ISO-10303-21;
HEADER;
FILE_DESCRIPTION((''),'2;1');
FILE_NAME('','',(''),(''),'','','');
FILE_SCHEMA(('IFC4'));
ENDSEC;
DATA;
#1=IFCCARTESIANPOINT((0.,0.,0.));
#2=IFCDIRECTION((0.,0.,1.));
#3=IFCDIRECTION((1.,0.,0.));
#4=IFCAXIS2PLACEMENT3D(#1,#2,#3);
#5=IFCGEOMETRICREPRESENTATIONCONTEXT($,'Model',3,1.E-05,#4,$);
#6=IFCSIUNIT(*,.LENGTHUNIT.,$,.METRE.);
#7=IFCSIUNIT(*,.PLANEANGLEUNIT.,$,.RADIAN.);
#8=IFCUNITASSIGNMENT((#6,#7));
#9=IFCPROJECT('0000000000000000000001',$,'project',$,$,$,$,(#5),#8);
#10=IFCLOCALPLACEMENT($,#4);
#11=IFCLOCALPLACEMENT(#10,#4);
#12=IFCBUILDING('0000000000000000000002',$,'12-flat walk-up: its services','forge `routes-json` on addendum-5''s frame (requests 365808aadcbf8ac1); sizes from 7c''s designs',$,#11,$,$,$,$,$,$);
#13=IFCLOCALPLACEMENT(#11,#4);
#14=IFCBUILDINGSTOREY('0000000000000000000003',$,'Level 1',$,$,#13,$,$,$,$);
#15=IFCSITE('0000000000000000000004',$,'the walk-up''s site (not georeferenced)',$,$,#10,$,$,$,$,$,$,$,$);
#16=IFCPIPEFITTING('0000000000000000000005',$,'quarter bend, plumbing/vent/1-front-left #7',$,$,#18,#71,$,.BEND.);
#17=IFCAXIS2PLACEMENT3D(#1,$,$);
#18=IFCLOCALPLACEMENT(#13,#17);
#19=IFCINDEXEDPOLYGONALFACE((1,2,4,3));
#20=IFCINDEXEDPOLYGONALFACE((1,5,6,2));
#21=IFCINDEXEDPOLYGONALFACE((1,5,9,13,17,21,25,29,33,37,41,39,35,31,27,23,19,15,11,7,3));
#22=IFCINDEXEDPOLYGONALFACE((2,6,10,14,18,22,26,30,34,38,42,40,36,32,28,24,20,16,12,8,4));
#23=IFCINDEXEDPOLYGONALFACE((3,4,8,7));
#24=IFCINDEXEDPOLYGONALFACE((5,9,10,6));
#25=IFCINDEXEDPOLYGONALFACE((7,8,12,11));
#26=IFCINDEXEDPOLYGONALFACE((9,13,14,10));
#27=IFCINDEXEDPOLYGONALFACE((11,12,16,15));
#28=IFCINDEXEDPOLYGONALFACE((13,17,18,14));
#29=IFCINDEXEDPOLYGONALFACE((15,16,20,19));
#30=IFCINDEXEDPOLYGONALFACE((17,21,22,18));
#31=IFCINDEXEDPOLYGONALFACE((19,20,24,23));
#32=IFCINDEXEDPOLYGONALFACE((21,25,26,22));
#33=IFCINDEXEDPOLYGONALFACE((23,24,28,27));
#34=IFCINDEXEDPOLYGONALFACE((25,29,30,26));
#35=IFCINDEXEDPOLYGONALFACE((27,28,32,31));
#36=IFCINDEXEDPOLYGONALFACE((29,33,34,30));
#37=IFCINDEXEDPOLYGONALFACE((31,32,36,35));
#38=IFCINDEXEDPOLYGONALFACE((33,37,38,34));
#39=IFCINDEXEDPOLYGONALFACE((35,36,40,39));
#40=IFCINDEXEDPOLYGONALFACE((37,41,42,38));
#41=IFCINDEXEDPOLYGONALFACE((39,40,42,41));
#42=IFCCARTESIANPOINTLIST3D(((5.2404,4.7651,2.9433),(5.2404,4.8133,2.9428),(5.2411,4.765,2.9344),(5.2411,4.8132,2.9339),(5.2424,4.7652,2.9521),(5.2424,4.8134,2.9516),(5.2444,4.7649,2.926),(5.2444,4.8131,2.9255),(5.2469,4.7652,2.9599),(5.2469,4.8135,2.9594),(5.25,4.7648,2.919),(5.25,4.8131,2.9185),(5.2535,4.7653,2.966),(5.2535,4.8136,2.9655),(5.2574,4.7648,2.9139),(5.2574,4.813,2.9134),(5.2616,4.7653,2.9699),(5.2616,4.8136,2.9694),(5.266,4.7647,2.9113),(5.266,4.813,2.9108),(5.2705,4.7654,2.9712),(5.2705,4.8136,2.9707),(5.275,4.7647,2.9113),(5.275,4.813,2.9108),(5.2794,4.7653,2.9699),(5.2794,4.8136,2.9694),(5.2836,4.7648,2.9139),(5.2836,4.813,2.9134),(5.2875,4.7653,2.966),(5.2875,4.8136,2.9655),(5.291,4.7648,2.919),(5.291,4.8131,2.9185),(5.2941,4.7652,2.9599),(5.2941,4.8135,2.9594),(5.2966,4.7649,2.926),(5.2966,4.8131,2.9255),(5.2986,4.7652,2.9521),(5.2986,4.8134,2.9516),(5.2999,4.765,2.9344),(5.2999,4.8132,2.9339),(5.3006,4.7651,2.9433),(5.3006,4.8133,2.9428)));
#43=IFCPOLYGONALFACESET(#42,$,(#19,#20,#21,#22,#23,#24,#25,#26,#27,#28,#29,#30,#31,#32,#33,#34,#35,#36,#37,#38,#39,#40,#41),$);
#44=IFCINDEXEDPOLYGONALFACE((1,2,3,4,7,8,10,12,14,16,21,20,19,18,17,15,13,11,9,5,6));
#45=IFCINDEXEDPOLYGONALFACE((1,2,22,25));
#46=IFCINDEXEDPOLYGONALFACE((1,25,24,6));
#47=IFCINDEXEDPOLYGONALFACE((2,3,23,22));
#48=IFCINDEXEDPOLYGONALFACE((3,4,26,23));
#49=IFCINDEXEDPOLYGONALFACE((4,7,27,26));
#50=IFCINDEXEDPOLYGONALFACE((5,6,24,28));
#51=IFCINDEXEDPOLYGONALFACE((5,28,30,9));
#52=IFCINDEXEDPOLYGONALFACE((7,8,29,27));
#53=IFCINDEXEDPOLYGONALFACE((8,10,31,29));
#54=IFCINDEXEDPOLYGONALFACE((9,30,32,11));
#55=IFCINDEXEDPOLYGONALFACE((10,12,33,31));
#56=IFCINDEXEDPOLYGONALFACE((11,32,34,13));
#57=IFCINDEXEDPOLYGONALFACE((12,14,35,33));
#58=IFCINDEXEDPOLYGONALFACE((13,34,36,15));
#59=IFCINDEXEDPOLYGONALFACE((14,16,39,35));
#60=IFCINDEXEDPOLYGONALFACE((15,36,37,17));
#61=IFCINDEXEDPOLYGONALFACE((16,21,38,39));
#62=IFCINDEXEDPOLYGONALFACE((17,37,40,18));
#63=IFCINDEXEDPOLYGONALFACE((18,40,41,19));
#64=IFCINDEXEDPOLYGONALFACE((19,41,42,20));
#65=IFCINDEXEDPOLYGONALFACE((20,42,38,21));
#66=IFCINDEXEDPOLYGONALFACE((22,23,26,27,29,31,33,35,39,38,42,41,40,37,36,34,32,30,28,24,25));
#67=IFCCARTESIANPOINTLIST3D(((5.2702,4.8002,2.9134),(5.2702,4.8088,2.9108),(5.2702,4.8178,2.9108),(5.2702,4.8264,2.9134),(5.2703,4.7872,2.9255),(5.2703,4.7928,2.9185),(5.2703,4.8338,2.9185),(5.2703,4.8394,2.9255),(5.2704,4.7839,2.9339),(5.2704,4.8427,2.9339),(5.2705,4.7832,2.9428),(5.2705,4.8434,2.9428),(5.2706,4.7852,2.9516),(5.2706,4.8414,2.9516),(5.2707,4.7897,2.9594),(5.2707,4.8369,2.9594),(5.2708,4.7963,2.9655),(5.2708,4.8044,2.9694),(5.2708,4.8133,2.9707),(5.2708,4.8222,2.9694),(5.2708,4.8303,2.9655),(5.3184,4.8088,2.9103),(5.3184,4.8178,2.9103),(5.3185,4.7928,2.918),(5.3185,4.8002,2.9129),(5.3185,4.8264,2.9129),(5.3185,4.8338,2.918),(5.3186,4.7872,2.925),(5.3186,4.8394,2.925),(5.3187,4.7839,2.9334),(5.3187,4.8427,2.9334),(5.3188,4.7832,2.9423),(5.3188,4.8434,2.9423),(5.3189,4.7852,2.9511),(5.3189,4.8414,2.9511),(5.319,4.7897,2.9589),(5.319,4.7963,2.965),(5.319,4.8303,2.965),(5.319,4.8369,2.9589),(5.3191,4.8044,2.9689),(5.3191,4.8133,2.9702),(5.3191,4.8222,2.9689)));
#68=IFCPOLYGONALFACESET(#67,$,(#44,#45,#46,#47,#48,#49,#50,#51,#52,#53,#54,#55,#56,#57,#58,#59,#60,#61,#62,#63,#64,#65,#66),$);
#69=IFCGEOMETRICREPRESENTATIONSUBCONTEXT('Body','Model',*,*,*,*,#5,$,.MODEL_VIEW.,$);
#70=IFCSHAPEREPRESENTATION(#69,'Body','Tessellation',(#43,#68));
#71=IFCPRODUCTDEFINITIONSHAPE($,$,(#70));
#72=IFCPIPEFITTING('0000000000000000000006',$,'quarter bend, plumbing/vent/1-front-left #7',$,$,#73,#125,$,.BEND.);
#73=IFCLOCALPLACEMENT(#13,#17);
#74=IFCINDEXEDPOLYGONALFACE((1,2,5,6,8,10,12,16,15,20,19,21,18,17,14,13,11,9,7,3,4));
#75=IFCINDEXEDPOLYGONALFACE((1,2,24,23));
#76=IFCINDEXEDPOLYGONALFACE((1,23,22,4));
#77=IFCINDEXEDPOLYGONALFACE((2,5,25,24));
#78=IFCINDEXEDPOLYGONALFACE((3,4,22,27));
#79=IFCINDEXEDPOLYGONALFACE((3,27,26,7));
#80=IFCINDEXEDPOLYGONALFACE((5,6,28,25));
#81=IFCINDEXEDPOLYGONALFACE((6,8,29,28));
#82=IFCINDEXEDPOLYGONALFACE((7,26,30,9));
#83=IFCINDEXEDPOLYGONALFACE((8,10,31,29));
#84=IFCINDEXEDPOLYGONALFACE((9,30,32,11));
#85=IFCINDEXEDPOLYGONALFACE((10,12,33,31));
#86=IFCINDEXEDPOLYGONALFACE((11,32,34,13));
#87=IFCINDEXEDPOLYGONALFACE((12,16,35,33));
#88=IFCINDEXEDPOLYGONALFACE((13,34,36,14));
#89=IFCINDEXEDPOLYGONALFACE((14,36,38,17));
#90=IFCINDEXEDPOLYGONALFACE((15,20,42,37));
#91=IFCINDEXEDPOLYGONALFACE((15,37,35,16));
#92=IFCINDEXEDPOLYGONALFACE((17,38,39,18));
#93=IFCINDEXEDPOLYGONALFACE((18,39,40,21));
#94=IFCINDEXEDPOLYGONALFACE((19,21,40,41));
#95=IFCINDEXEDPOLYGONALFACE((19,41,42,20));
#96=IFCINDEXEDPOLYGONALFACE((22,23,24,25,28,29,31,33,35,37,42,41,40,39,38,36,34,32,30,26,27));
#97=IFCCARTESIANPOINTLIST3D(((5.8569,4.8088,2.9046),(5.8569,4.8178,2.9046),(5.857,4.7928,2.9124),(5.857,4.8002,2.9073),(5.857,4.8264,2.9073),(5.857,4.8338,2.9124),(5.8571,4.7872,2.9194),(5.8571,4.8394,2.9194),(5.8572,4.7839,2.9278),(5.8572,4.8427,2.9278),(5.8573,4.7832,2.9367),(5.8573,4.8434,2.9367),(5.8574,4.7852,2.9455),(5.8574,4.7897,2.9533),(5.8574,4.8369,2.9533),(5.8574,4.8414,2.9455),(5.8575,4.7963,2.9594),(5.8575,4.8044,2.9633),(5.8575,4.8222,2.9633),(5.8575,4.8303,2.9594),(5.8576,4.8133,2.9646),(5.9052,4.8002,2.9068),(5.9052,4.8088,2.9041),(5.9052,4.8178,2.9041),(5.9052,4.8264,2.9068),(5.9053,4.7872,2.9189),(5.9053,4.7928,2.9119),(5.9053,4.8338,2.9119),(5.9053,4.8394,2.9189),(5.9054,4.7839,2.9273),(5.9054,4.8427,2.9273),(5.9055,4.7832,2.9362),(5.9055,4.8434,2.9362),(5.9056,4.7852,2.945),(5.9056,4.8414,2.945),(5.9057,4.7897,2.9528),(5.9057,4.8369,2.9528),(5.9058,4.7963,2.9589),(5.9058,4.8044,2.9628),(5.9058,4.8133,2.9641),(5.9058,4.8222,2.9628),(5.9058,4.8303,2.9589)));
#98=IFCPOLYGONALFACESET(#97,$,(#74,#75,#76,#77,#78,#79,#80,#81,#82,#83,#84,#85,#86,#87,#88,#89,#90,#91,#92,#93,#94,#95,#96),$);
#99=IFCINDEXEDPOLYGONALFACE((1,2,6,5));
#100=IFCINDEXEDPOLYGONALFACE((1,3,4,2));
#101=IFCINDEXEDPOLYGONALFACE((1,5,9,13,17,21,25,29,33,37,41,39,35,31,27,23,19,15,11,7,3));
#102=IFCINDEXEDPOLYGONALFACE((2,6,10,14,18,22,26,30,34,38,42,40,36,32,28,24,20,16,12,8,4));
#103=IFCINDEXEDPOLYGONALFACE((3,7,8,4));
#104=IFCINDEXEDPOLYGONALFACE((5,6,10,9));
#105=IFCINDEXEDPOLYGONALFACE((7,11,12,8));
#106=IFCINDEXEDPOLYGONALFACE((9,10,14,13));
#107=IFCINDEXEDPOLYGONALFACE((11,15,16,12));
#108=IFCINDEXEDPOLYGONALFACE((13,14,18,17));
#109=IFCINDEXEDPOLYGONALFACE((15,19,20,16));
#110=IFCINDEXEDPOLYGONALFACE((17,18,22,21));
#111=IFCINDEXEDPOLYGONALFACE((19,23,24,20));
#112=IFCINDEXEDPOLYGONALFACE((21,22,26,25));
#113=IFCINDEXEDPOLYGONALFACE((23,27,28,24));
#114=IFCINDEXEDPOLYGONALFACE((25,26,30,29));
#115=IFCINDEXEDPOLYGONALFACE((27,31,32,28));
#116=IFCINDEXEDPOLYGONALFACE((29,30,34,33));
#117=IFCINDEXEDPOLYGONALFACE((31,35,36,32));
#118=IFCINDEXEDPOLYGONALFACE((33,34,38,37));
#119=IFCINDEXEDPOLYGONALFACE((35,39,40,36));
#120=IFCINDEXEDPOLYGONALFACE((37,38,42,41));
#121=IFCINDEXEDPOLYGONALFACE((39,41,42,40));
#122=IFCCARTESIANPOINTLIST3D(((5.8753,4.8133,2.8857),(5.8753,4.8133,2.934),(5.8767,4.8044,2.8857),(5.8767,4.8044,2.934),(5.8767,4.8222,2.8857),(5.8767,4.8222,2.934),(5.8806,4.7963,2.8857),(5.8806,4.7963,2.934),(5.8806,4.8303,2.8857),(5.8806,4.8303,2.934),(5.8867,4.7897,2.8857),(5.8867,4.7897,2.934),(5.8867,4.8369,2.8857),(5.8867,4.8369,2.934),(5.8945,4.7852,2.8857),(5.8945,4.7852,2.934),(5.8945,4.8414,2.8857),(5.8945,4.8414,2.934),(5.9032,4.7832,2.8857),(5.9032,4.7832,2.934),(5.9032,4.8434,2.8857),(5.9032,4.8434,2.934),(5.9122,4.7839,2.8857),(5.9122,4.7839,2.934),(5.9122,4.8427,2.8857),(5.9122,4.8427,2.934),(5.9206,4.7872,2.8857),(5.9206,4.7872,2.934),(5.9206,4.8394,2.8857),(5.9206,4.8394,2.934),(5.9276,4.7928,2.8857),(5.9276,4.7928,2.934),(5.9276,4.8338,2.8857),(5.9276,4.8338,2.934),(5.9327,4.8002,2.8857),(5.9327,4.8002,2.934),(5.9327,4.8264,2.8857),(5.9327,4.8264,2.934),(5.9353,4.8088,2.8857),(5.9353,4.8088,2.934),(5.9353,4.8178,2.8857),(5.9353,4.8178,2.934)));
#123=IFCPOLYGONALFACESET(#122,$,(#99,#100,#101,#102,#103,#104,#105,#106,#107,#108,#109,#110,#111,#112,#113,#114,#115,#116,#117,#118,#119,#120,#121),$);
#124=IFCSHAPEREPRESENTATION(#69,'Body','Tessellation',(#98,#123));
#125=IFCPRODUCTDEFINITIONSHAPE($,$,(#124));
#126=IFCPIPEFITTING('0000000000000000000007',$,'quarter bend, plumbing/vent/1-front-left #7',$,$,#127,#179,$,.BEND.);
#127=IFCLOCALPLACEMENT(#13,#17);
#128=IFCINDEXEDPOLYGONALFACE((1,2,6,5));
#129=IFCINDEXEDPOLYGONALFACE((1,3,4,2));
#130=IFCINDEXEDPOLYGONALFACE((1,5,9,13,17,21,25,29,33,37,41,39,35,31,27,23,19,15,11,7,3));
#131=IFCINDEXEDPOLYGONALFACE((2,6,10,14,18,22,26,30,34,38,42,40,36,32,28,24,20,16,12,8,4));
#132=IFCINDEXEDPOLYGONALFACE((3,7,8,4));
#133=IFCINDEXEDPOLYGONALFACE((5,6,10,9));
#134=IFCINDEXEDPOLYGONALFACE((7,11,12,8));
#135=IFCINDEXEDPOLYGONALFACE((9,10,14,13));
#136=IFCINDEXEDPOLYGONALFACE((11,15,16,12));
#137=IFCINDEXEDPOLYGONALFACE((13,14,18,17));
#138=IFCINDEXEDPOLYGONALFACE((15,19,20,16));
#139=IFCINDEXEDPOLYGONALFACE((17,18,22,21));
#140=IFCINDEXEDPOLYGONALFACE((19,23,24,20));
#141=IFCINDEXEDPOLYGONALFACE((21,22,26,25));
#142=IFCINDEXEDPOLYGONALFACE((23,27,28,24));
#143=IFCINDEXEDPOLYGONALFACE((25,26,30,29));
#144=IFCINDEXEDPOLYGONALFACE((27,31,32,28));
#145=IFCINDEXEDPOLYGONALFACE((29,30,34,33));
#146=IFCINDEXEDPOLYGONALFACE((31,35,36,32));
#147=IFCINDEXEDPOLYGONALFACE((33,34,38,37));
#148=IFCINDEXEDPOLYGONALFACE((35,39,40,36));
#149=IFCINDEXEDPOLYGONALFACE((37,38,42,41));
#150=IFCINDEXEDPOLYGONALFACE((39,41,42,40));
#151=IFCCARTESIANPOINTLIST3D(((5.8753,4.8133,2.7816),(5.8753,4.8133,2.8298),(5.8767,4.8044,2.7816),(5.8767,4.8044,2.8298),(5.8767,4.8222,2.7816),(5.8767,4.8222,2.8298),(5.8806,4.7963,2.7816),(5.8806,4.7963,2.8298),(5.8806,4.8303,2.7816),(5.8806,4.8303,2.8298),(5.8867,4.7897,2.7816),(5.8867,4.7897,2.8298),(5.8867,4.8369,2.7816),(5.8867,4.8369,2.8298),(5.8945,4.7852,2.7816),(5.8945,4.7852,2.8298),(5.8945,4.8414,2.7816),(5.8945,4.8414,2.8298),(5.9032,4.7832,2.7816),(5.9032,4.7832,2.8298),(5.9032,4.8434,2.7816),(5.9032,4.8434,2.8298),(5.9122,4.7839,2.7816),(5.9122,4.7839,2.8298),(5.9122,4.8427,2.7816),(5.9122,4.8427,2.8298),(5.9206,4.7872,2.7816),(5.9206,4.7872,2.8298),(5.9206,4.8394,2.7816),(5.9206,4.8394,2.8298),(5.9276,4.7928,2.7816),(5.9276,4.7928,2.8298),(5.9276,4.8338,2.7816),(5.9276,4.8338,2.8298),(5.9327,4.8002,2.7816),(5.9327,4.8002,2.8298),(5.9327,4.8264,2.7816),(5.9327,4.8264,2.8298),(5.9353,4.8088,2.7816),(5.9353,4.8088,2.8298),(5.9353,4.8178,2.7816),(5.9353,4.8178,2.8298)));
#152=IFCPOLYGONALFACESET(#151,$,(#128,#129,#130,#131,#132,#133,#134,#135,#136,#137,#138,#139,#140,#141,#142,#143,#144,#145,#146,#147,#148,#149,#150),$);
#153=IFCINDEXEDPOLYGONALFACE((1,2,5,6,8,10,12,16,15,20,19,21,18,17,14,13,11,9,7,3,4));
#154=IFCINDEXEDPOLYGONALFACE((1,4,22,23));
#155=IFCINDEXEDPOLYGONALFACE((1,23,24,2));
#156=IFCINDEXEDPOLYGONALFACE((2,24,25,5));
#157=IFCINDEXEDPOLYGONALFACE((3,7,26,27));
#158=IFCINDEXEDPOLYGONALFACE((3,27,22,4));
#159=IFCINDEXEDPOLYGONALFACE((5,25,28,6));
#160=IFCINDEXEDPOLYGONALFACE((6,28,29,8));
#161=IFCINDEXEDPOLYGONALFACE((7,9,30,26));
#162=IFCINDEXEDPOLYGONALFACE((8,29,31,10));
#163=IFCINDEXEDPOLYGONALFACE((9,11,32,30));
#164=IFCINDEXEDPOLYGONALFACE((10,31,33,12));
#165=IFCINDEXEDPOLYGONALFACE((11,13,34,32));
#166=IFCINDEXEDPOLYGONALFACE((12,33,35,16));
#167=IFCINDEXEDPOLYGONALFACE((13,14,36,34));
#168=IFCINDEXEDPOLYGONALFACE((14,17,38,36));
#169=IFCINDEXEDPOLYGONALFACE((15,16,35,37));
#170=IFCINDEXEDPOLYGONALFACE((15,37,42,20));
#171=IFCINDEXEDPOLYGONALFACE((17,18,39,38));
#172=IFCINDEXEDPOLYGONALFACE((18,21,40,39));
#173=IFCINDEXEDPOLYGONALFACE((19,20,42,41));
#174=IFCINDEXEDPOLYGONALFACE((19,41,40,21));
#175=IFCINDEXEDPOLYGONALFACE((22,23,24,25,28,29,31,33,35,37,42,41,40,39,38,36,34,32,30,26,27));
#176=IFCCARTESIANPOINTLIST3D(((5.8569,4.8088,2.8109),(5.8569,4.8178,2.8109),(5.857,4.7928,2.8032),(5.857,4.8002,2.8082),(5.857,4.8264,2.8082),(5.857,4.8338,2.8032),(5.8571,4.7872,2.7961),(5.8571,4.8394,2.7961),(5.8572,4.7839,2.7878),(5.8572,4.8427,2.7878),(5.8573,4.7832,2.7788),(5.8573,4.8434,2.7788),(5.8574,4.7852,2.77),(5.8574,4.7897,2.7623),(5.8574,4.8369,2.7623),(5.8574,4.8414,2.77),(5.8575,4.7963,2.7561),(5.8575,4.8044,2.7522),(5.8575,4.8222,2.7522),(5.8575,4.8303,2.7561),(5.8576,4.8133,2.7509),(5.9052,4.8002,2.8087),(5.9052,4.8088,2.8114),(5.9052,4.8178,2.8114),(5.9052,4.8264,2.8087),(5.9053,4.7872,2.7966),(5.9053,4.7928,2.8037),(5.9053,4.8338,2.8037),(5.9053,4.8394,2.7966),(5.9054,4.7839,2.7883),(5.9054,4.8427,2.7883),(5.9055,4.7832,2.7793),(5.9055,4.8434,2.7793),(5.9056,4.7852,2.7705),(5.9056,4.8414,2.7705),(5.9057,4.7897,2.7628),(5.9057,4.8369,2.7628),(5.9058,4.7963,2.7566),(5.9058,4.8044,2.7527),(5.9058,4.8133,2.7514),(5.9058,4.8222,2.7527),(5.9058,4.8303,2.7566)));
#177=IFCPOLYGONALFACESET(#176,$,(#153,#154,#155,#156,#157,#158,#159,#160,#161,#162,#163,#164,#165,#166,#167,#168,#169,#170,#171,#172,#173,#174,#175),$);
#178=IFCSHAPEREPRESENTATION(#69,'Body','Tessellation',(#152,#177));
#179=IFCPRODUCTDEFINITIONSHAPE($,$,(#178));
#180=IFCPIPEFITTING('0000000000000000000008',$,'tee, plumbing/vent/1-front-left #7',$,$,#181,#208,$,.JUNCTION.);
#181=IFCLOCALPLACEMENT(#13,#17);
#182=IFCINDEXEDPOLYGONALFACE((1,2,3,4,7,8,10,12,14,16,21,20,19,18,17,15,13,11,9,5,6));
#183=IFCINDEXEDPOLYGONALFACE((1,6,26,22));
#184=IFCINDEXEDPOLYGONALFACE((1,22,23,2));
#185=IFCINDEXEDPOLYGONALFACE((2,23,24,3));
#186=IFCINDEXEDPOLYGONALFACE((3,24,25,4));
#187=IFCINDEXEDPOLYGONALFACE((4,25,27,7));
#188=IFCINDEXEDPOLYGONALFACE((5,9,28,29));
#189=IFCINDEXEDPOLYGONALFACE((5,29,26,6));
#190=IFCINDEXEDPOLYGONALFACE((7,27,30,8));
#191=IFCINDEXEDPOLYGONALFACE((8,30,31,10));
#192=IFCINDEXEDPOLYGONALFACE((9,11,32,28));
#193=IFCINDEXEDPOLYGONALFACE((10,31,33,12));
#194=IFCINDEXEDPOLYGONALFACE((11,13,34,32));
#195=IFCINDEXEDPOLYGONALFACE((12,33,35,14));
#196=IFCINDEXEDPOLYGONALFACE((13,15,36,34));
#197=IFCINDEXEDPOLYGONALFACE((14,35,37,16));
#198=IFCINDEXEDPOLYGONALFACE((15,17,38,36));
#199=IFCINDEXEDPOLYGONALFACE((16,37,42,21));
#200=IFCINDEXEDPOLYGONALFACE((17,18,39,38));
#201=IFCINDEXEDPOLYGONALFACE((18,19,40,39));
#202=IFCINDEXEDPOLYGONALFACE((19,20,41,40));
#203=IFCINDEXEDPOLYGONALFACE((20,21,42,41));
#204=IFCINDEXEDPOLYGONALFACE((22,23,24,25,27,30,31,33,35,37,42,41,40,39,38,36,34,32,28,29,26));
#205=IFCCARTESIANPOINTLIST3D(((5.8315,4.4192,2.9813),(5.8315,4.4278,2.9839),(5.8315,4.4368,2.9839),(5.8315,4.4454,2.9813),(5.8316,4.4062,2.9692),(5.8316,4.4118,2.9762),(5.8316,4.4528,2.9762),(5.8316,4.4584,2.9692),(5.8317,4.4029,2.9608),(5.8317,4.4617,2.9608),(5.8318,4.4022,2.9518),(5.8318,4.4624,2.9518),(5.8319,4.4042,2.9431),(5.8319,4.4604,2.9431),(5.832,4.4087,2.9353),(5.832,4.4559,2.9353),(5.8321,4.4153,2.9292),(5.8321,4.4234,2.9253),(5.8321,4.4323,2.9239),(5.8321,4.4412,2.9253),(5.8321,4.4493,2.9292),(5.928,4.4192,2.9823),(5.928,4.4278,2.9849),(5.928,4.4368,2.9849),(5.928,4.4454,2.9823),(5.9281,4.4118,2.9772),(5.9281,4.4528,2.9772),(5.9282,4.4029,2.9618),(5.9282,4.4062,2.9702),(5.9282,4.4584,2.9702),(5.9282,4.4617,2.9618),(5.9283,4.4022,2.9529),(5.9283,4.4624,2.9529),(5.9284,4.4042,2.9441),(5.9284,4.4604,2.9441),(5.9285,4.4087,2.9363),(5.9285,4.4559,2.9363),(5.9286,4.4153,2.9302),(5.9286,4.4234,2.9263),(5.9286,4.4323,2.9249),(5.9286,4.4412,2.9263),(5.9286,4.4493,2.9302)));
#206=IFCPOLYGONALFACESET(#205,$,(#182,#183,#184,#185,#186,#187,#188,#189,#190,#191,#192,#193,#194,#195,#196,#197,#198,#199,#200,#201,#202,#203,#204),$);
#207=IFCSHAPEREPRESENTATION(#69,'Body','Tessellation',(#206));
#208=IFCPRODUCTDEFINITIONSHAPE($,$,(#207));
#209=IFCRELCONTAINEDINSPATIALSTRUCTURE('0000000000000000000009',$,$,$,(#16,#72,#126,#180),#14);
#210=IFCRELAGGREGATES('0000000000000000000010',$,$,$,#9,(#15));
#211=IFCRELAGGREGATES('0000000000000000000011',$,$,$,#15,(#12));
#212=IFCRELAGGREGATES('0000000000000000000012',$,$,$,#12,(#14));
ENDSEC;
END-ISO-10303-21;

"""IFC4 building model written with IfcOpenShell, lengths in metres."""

from ifc_helpers import new_model, entity, si_unit, frame, origin_with_axes, place, context, subcontext, project, spatial, element, save


model = new_model("IFC4")

# Units and contexts
model_context = context("Model", 3, precision=1e-05, world=origin_with_axes())
body_context = subcontext(model_context, "Body", "Model", "MODEL_VIEW")
ifc_project = project(units=[si_unit("LENGTHUNIT", "METRE"), si_unit("PLANEANGLEUNIT", "RADIAN")], contexts=[model_context])

# Site, building, storey
site_placement = place(None, origin_with_axes())
site = spatial("IfcSite", under=ifc_project, at=site_placement, Name="the walk-up's site (not georeferenced)")
building_placement = place(site_placement, origin_with_axes())
building = spatial("IfcBuilding", under=site, at=building_placement, Name="12-flat walk-up: its services", Description="forge `routes-json` on addendum-5's frame (requests 365808aadcbf8ac1); sizes from 7c's designs")
storey_placement = place(building_placement, origin_with_axes())
storey = spatial("IfcBuildingStorey", under=building, at=storey_placement, Name="Level 1")

# Pipe fittings
pipe_fitting_1_placement = place(storey_placement, frame((5.2705, 4.765, 2.9411), z_axis=(0.0, 0.0, 1.0), x_axis=(1.0, 0.0, 0.0)))
element("IfcPipeFitting", 1, at=pipe_fitting_1_placement, inside=storey, Name="quarter bend, plumbing/vent/1-front-left #7", PredefinedType="BEND", context=body_context, shape_type="AdvancedSweptSolid", body=[
    entity("IfcSweptDiskSolid", entity("IfcPolyline", [entity("IfcCartesianPoint", [0.0, 0.0, 0.0]), entity("IfcCartesianPoint", [0.0, 0.0483, -0.0005])]), 0.0302),
    entity("IfcSweptDiskSolid", entity("IfcPolyline", [entity("IfcCartesianPoint", [0.0, 0.0483, -0.0005]), entity("IfcCartesianPoint", [0.0483, 0.0483, -0.001])]), 0.0302),
])
pipe_fitting_2_placement = place(storey_placement, frame((5.8572, 4.8133, 2.9345), z_axis=(0.0, 0.0, 1.0), x_axis=(1.0, 0.0, 0.0)))
element("IfcPipeFitting", 2, at=pipe_fitting_2_placement, inside=storey, Name="quarter bend, plumbing/vent/1-front-left #7", PredefinedType="BEND", context=body_context, shape_type="AdvancedSweptSolid", body=[
    entity("IfcSweptDiskSolid", entity("IfcPolyline", [entity("IfcCartesianPoint", [0.0, 0.0, 0.0]), entity("IfcCartesianPoint", [0.0483, 0.0, -0.0005])]), 0.0302),
    entity("IfcSweptDiskSolid", entity("IfcPolyline", [entity("IfcCartesianPoint", [0.0483, 0.0, -0.0005]), entity("IfcCartesianPoint", [0.0483, 0.0, -0.0488])]), 0.0302),
])
pipe_fitting_3_placement = place(storey_placement, frame((5.9055, 4.8133, 2.8298), z_axis=(0.0, 0.0, 1.0), x_axis=(1.0, 0.0, 0.0)))
element("IfcPipeFitting", 3, at=pipe_fitting_3_placement, inside=storey, Name="quarter bend, plumbing/vent/1-front-left #7", PredefinedType="BEND", context=body_context, shape_type="AdvancedSweptSolid", body=[
    entity("IfcSweptDiskSolid", entity("IfcPolyline", [entity("IfcCartesianPoint", [0.0, 0.0, 0.0]), entity("IfcCartesianPoint", [0.0, 0.0, -0.0483])]), 0.0302),
    entity("IfcSweptDiskSolid", entity("IfcPolyline", [entity("IfcCartesianPoint", [0.0, 0.0, -0.0483]), entity("IfcCartesianPoint", [-0.0483, 0.0, -0.0488])]), 0.0302),
])
pipe_fitting_4_placement = place(storey_placement, frame((5.9283, 4.4323, 2.9551), z_axis=(0.0, 0.0, 1.0), x_axis=(1.0, 0.0, 0.0)))
element("IfcPipeFitting", 4, at=pipe_fitting_4_placement, inside=storey, Name="tee, plumbing/vent/1-front-left #7", PredefinedType="JUNCTION", context=body_context, shape_type="AdvancedSweptSolid", body=[
    entity("IfcSweptDiskSolid", entity("IfcPolyline", [entity("IfcCartesianPoint", [0.0, 0.0, 0.0]), entity("IfcCartesianPoint", [-0.0965, 0.0, -0.001])]), 0.0302),
])

save(model, "model.ifc")
